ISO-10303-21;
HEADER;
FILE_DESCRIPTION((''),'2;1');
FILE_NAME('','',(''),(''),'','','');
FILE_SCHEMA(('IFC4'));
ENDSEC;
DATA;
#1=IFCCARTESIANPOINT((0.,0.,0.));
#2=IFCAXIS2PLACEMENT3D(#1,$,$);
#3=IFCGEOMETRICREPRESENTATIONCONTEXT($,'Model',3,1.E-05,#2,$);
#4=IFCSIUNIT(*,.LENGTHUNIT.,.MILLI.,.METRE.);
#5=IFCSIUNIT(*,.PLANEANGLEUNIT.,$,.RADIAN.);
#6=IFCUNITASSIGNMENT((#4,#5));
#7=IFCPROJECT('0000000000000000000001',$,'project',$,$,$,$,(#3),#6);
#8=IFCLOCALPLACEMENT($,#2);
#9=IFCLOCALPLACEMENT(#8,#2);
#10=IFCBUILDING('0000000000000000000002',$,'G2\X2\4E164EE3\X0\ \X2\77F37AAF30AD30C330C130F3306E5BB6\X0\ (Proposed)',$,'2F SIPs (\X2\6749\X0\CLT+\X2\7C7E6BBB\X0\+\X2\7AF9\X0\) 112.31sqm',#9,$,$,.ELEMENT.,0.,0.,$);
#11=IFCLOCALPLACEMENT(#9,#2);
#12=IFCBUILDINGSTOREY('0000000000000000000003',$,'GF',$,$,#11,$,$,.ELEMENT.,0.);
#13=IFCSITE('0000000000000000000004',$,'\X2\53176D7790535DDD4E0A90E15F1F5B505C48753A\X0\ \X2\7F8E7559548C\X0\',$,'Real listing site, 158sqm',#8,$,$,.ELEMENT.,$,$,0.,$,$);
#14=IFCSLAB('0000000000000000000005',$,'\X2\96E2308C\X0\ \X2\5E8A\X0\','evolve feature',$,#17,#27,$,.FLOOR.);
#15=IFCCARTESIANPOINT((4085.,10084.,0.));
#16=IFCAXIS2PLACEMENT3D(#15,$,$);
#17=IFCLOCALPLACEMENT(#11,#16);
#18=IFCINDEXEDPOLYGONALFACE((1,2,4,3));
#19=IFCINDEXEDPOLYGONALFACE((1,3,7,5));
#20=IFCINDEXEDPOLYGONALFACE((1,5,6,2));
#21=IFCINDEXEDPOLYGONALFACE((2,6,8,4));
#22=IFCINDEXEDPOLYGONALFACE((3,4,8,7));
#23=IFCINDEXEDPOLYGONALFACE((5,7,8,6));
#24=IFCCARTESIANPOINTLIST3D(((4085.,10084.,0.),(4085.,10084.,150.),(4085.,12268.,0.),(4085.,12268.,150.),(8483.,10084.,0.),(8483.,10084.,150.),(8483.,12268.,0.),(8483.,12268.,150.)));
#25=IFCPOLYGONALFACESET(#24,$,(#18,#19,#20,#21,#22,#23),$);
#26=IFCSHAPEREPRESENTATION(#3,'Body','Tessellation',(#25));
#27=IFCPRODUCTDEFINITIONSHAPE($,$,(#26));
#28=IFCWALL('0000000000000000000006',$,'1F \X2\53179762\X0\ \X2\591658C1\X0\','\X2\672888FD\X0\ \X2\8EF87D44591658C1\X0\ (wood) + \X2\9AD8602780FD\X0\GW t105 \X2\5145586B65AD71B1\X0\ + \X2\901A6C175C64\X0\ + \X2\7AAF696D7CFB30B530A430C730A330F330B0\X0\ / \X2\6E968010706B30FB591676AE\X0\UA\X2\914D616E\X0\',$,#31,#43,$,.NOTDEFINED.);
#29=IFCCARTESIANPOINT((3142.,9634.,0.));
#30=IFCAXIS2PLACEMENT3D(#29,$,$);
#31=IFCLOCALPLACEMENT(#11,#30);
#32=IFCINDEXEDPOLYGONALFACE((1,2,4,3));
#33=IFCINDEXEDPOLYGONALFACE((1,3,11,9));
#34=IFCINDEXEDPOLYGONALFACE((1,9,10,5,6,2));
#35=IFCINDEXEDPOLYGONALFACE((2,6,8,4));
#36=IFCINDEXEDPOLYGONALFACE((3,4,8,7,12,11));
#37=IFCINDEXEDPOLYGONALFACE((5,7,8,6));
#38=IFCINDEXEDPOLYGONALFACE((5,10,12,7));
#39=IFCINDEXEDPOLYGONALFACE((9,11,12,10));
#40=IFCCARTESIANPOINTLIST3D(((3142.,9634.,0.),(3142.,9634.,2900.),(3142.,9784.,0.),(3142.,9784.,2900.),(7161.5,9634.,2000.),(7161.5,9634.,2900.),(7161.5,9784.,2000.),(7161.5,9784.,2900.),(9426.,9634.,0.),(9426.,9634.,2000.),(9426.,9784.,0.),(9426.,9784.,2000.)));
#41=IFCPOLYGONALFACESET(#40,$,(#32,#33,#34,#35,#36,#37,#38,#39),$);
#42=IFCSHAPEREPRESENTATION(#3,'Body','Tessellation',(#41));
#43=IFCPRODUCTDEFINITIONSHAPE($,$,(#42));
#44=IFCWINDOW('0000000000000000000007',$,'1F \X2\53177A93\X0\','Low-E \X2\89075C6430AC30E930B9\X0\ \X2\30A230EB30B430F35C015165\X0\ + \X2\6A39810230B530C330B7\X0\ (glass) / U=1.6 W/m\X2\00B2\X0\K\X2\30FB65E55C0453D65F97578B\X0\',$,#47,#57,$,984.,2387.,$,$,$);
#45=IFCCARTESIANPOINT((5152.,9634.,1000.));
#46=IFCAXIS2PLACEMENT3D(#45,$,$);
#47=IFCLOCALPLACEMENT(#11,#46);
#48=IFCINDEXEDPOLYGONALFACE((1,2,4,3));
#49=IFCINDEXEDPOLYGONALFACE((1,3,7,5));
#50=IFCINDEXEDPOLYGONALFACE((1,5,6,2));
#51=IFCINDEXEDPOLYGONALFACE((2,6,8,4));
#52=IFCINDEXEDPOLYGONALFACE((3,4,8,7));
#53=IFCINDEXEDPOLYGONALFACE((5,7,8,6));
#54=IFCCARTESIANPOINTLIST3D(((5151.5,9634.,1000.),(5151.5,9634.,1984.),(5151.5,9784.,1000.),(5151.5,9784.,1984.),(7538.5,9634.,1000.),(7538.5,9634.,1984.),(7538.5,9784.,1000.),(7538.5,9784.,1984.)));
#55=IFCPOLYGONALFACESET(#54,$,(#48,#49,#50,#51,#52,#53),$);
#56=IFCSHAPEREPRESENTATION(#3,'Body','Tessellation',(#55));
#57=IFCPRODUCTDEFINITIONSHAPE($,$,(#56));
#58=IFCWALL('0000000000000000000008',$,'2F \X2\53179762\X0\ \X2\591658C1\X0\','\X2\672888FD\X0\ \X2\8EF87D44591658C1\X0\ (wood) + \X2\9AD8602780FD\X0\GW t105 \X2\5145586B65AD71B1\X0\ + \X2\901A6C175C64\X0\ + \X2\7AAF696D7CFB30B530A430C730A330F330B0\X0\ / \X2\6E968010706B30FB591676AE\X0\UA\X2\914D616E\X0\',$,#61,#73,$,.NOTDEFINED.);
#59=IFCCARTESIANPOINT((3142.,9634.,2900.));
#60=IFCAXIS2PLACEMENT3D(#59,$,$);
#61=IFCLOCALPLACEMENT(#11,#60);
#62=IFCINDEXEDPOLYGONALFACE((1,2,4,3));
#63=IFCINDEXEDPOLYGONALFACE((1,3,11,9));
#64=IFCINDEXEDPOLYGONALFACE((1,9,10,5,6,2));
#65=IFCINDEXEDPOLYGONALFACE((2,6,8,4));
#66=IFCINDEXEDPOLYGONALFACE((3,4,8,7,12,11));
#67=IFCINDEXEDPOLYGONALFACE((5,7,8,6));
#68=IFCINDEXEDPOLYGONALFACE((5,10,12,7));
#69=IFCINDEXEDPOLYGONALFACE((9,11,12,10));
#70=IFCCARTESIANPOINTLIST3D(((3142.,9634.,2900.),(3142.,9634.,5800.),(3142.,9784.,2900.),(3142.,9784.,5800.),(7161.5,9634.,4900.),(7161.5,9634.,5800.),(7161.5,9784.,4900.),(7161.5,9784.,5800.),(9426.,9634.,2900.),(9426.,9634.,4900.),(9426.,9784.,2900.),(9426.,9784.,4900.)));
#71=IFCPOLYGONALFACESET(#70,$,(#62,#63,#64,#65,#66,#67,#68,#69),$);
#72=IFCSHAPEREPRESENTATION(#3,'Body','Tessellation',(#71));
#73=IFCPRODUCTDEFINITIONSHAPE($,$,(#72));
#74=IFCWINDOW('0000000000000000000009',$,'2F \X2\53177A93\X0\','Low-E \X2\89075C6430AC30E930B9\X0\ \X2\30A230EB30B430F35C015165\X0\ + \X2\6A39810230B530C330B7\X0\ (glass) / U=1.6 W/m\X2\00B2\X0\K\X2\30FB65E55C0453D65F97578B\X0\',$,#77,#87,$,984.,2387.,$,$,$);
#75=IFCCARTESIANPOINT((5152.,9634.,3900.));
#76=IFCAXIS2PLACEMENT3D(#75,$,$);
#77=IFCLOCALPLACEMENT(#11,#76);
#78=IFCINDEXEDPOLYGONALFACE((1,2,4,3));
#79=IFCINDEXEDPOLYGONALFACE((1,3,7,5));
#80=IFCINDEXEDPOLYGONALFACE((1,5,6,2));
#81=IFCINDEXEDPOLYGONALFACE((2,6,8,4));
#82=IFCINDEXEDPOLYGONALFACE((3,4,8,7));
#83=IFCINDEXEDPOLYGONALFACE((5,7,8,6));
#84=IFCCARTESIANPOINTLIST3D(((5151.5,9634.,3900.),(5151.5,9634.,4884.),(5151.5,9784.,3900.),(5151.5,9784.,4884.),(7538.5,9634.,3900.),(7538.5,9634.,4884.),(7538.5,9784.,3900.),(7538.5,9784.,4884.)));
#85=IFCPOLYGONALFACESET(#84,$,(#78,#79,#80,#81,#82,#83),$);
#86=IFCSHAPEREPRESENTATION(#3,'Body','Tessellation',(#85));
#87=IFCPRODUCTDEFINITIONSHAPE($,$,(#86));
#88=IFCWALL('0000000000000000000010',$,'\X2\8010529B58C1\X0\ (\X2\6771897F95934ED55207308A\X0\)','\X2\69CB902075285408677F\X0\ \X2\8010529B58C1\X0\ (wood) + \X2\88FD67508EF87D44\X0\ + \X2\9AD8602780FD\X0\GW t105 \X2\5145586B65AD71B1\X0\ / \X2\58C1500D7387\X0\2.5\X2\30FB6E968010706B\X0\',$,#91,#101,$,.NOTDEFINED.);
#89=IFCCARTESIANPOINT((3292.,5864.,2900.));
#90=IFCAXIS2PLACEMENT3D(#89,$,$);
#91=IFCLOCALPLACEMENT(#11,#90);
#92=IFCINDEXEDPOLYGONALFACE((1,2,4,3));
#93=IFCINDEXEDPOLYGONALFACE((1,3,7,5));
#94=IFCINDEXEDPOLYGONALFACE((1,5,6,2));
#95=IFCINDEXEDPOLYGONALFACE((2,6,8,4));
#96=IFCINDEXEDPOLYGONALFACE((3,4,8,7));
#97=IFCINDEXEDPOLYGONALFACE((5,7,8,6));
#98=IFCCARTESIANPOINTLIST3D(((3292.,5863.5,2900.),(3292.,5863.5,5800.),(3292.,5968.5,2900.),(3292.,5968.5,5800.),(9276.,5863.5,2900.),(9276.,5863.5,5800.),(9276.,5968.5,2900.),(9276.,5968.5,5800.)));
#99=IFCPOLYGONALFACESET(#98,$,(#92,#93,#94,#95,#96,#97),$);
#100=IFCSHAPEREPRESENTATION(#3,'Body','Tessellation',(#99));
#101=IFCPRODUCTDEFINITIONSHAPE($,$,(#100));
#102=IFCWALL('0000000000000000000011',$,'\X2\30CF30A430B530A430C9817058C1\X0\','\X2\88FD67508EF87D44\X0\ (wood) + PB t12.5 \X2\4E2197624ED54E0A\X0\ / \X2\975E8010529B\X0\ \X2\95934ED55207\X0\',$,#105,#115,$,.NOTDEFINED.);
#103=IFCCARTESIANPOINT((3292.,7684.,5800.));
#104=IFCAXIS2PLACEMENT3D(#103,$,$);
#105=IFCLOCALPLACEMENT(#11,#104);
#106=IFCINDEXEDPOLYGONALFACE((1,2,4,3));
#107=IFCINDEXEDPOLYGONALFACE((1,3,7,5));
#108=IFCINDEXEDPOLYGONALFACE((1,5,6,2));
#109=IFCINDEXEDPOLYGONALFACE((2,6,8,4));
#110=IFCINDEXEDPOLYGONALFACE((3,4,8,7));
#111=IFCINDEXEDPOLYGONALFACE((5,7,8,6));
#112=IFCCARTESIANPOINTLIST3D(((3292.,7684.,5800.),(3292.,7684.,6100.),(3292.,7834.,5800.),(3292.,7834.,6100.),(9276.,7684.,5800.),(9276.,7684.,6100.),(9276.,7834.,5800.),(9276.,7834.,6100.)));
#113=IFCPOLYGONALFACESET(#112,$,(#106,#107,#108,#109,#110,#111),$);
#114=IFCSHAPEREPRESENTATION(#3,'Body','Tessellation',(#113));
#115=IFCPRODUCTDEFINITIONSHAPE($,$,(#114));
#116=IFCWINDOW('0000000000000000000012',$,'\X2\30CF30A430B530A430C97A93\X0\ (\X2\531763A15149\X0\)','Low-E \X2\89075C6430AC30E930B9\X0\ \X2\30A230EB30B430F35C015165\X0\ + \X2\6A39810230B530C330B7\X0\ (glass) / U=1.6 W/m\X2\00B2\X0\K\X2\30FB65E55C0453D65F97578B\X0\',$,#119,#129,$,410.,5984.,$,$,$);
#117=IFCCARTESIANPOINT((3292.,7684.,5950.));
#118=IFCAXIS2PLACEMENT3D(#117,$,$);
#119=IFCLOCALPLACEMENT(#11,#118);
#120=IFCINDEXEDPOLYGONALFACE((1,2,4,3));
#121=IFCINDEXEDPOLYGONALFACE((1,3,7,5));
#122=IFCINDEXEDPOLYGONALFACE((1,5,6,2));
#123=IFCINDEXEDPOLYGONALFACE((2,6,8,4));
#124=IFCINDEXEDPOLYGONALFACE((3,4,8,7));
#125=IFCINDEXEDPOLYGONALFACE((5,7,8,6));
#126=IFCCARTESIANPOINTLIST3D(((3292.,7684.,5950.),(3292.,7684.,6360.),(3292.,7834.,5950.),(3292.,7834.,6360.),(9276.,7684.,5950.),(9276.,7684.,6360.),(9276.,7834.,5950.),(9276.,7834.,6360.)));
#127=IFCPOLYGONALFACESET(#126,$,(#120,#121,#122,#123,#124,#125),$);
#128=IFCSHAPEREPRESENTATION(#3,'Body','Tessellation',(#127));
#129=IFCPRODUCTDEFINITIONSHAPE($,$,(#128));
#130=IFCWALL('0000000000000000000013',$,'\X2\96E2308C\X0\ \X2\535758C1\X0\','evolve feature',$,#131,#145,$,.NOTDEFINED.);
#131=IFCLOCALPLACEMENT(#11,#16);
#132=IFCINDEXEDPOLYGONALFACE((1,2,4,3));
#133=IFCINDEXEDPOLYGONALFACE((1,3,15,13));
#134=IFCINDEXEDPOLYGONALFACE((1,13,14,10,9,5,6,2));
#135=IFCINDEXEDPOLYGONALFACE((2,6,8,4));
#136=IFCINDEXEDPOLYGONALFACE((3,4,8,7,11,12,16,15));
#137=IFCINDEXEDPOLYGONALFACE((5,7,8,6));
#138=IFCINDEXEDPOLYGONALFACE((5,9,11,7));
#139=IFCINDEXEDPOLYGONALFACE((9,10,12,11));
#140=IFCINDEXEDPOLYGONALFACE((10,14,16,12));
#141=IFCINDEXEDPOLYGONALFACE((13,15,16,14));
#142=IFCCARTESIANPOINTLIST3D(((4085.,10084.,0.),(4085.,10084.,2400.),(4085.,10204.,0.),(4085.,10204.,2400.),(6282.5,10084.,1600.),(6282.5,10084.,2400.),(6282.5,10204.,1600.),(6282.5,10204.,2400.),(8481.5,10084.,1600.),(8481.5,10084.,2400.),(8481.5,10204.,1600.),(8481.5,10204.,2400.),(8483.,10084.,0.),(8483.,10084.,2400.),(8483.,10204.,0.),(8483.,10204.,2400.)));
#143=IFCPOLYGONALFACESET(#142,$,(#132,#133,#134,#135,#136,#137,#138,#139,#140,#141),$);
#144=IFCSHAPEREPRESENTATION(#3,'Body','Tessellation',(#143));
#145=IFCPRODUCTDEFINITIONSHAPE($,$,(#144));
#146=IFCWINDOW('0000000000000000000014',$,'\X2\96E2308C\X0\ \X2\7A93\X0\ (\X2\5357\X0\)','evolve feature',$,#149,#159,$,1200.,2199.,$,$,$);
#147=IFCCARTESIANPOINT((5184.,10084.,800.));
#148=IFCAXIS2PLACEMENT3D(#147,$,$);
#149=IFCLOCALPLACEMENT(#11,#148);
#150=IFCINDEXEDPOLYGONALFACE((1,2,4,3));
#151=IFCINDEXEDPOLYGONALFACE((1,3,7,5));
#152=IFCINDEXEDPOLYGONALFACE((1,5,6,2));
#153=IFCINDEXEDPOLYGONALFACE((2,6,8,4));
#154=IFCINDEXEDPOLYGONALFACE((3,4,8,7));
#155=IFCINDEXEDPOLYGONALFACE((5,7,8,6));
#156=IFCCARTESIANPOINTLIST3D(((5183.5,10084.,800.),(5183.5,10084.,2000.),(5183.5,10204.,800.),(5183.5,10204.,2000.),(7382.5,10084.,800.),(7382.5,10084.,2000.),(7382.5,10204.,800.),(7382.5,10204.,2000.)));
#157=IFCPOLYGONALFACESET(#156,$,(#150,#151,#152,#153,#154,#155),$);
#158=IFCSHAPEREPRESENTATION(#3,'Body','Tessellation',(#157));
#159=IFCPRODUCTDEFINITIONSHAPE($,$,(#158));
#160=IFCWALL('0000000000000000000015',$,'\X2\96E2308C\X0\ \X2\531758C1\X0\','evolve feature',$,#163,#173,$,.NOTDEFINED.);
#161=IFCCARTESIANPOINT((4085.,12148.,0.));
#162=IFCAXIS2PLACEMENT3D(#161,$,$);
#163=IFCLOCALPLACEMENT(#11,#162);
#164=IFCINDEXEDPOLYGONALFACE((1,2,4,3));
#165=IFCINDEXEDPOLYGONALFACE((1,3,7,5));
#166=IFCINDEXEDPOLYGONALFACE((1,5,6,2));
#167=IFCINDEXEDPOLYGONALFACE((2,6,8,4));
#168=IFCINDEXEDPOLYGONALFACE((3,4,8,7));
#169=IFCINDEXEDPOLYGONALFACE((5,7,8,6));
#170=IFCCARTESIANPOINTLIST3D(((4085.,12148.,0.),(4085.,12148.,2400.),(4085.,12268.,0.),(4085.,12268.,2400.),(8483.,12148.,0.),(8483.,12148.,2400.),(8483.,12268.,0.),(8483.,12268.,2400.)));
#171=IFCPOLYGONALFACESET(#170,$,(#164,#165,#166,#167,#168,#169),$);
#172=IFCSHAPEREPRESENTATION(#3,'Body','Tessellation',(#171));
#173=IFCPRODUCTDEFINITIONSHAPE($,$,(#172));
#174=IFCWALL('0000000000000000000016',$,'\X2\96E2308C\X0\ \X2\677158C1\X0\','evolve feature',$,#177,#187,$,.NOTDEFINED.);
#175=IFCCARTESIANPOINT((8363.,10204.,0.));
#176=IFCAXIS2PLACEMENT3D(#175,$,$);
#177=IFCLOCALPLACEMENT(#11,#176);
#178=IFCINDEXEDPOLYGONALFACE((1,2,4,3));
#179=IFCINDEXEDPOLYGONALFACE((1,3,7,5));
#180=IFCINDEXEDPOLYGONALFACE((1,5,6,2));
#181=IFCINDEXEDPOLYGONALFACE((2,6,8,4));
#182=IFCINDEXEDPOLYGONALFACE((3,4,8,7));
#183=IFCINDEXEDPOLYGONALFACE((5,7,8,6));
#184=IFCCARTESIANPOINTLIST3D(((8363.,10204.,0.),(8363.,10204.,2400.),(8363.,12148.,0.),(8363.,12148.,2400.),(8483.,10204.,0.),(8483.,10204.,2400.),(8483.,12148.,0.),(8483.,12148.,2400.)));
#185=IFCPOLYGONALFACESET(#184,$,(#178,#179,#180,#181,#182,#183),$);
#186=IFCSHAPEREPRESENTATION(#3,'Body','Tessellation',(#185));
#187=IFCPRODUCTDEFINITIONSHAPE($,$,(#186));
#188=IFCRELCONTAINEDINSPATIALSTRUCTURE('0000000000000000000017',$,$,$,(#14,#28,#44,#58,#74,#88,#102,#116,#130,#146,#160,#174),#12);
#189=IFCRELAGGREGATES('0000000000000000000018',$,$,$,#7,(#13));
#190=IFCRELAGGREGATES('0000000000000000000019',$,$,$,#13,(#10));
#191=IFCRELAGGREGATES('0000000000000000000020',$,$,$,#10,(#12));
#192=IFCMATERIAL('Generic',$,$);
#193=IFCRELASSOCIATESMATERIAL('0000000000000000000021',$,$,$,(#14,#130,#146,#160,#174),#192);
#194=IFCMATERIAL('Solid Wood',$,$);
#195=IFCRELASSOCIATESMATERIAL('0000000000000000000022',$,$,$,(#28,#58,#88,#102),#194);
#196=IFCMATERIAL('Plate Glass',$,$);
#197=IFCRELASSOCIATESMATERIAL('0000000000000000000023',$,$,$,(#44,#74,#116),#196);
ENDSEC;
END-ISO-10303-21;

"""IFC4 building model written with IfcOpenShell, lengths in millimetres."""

from ifc_helpers import new_model, si_unit, frame, frame_2d, origin, place, context, project, spatial, rectangle, extrude, material, element, fill, save


model = new_model("IFC4")

# Units and contexts
model_context = context("Model", 3, precision=1e-05, world=origin())
ifc_project = project(units=[si_unit("LENGTHUNIT", "METRE", prefix="MILLI"), si_unit("PLANEANGLEUNIT", "RADIAN")], contexts=[model_context])

# Site, building, storey
site_placement = place(None, origin())
site = spatial("IfcSite", under=ifc_project, at=site_placement, Name="北海道川上郡弟子屈町 美留和", ObjectType="Real listing site, 158sqm", CompositionType="ELEMENT", RefElevation=0.0)
building_placement = place(site_placement, origin())
building = spatial("IfcBuilding", under=site, at=building_placement, Name="G2世代 石窯キッチンの家 (Proposed)", ObjectType="2F SIPs (杉CLT+籾殻+竹) 112.31sqm", CompositionType="ELEMENT", ElevationOfRefHeight=0.0, ElevationOfTerrain=0.0)
storey_placement = place(building_placement, origin())
storey = spatial("IfcBuildingStorey", under=building, at=storey_placement, Name="GF", CompositionType="ELEMENT", Elevation=0.0)

# Slab
ifc_material_1 = material(Name="Generic")
slab_placement = place(storey_placement, frame((4085.0, 10084.0, 0.0)))
element("IfcSlab", 1, at=slab_placement, inside=storey, material=ifc_material_1, Name="離れ 床", Description="evolve feature", PredefinedType="FLOOR", context=model_context, shape_type="SweptSolid", body=[
    extrude(rectangle(XDim=4398.0, YDim=2184.0, at=frame_2d((2199.0, 1092.0))), frame((4085.0, 10084.0, 0.0)), (0.0, 0.0, 1.0), 150.0),
])

# Wall, opening, window
ifc_material_2 = material(Name="Solid Wood")
wall_1_placement = place(storey_placement, frame((3142.0, 9634.0, 0.0)))
wall_1 = element("IfcWall", 2, at=wall_1_placement, inside=storey, material=ifc_material_2, Name="1F 北面 外壁", Description="木製 軸組外壁 (wood) + 高性能GW t105 充填断熱 + 通気層 + 窯業系サイディング / 準耐火・外皮UA配慮", PredefinedType="NOTDEFINED", context=model_context, shape_type="SweptSolid", body=[
    extrude(rectangle(XDim=6284.0, YDim=150.0, at=frame_2d((3142.0, 75.0))), frame((3142.0, 9634.0, 0.0)), (0.0, 0.0, 1.0), 2900.0),
])
opening_1_placement = place(storey_placement, frame((5152.0, 9634.0, 1000.0)))
opening_1 = element("IfcOpeningElement", 3, at=opening_1_placement, cuts=wall_1, PredefinedType="NOTDEFINED", context=model_context, shape_type="SweptSolid", body=[
    extrude(rectangle(XDim=2387.0, YDim=150.0, at=frame_2d((1193.0, 75.0))), frame((5152.0, 9634.0, 1000.0)), (0.0, 0.0, 1.0), 984.0),
])
ifc_material_3 = material(Name="Plate Glass")
window_1_placement = place(storey_placement, frame((5152.0, 9634.0, 1000.0)))
window_1 = element("IfcWindow", 4, at=window_1_placement, inside=storey, material=ifc_material_3, Name="1F 北窓", Description="Low-E 複層ガラス アルゴン封入 + 樹脂サッシ (glass) / U=1.6 W/m²K・日射取得型", OverallHeight=984.0, OverallWidth=2387.0, context=model_context, shape_type="SweptSolid", body=[
    extrude(rectangle(XDim=2387.0, YDim=150.0, at=frame_2d((1193.0, 75.0))), frame((5152.0, 9634.0, 1000.0)), (0.0, 0.0, 1.0), 984.0),
])
fill(opening_1, window_1)

# Wall, opening, window
wall_2_placement = place(storey_placement, frame((3142.0, 9634.0, 2900.0)))
wall_2 = element("IfcWall", 5, at=wall_2_placement, inside=storey, material=ifc_material_2, Name="2F 北面 外壁", Description="木製 軸組外壁 (wood) + 高性能GW t105 充填断熱 + 通気層 + 窯業系サイディング / 準耐火・外皮UA配慮", PredefinedType="NOTDEFINED", context=model_context, shape_type="SweptSolid", body=[
    extrude(rectangle(XDim=6284.0, YDim=150.0, at=frame_2d((3142.0, 75.0))), frame((3142.0, 9634.0, 2900.0)), (0.0, 0.0, 1.0), 2900.0),
])
opening_2_placement = place(storey_placement, frame((5152.0, 9634.0, 3900.0)))
opening_2 = element("IfcOpeningElement", 6, at=opening_2_placement, cuts=wall_2, PredefinedType="NOTDEFINED", context=model_context, shape_type="SweptSolid", body=[
    extrude(rectangle(XDim=2387.0, YDim=150.0, at=frame_2d((1193.0, 75.0))), frame((5152.0, 9634.0, 3900.0)), (0.0, 0.0, 1.0), 984.0),
])
window_2_placement = place(storey_placement, frame((5152.0, 9634.0, 3900.0)))
window_2 = element("IfcWindow", 7, at=window_2_placement, inside=storey, material=ifc_material_3, Name="2F 北窓", Description="Low-E 複層ガラス アルゴン封入 + 樹脂サッシ (glass) / U=1.6 W/m²K・日射取得型", OverallHeight=984.0, OverallWidth=2387.0, context=model_context, shape_type="SweptSolid", body=[
    extrude(rectangle(XDim=2387.0, YDim=150.0, at=frame_2d((1193.0, 75.0))), frame((5152.0, 9634.0, 3900.0)), (0.0, 0.0, 1.0), 984.0),
])
fill(opening_2, window_2)

# Wall
wall_3_placement = place(storey_placement, frame((3292.0, 5864.0, 2900.0)))
element("IfcWall", 8, at=wall_3_placement, inside=storey, material=ifc_material_2, Name="耐力壁 (東西間仕切り)", Description="構造用合板 耐力壁 (wood) + 製材軸組 + 高性能GW t105 充填断熱 / 壁倍率2.5・準耐火", PredefinedType="NOTDEFINED", context=model_context, shape_type="SweptSolid", body=[
    extrude(rectangle(XDim=5984.0, YDim=105.0, at=frame_2d((2992.0, 52.0))), frame((3292.0, 5864.0, 2900.0)), (0.0, 0.0, 1.0), 2900.0),
])

# Walls, openings, windows
wall_4_placement = place(storey_placement, frame((3292.0, 7684.0, 5800.0)))
wall_4 = element("IfcWall", 9, at=wall_4_placement, inside=storey, material=ifc_material_2, Name="ハイサイド腰壁", Description="製材軸組 (wood) + PB t12.5 両面仕上 / 非耐力 間仕切", PredefinedType="NOTDEFINED", context=model_context, shape_type="SweptSolid", body=[
    extrude(rectangle(XDim=5984.0, YDim=150.0, at=frame_2d((2992.0, 75.0))), frame((3292.0, 7684.0, 5800.0)), (0.0, 0.0, 1.0), 700.0),
])
opening_3_placement = place(storey_placement, frame((3292.0, 7684.0, 5950.0)))
opening_3 = element("IfcOpeningElement", 10, at=opening_3_placement, cuts=wall_4, PredefinedType="NOTDEFINED", context=model_context, shape_type="SweptSolid", body=[
    extrude(rectangle(XDim=5984.0, YDim=150.0, at=frame_2d((2992.0, 75.0))), frame((3292.0, 7684.0, 5950.0)), (0.0, 0.0, 1.0), 410.0),
])
window_3_placement = place(storey_placement, frame((3292.0, 7684.0, 5950.0)))
window_3 = element("IfcWindow", 11, at=window_3_placement, inside=storey, material=ifc_material_3, Name="ハイサイド窓 (北採光)", Description="Low-E 複層ガラス アルゴン封入 + 樹脂サッシ (glass) / U=1.6 W/m²K・日射取得型", OverallHeight=410.0, OverallWidth=5984.0, context=model_context, shape_type="SweptSolid", body=[
    extrude(rectangle(XDim=5984.0, YDim=150.0, at=frame_2d((2992.0, 75.0))), frame((3292.0, 7684.0, 5950.0)), (0.0, 0.0, 1.0), 410.0),
])
fill(opening_3, window_3)
wall_5_placement = place(storey_placement, frame((4085.0, 10084.0, 0.0)))
wall_5 = element("IfcWall", 12, at=wall_5_placement, inside=storey, material=ifc_material_1, Name="離れ 南壁", Description="evolve feature", PredefinedType="NOTDEFINED", context=model_context, shape_type="SweptSolid", body=[
    extrude(rectangle(XDim=4398.0, YDim=120.0, at=frame_2d((2199.0, 60.0))), frame((4085.0, 10084.0, 0.0)), (0.0, 0.0, 1.0), 2400.0),
])
opening_4_placement = place(storey_placement, frame((5184.0, 10084.0, 800.0)))
opening_4 = element("IfcOpeningElement", 13, at=opening_4_placement, cuts=wall_5, PredefinedType="NOTDEFINED", context=model_context, shape_type="SweptSolid", body=[
    extrude(rectangle(XDim=2199.0, YDim=120.0, at=frame_2d((1099.0, 60.0))), frame((5184.0, 10084.0, 800.0)), (0.0, 0.0, 1.0), 1200.0),
])
window_4_placement = place(storey_placement, frame((5184.0, 10084.0, 800.0)))
window_4 = element("IfcWindow", 14, at=window_4_placement, inside=storey, material=ifc_material_1, Name="離れ 窓 (南)", Description="evolve feature", OverallHeight=1200.0, OverallWidth=2199.0, context=model_context, shape_type="SweptSolid", body=[
    extrude(rectangle(XDim=2199.0, YDim=120.0, at=frame_2d((1099.0, 60.0))), frame((5184.0, 10084.0, 800.0)), (0.0, 0.0, 1.0), 1200.0),
])
fill(opening_4, window_4)

# Walls
wall_6_placement = place(storey_placement, frame((4085.0, 12148.0, 0.0)))
element("IfcWall", 15, at=wall_6_placement, inside=storey, material=ifc_material_1, Name="離れ 北壁", Description="evolve feature", PredefinedType="NOTDEFINED", context=model_context, shape_type="SweptSolid", body=[
    extrude(rectangle(XDim=4398.0, YDim=120.0, at=frame_2d((2199.0, 60.0))), frame((4085.0, 12148.0, 0.0)), (0.0, 0.0, 1.0), 2400.0),
])
wall_7_placement = place(storey_placement, frame((8363.0, 10204.0, 0.0)))
element("IfcWall", 16, at=wall_7_placement, inside=storey, material=ifc_material_1, Name="離れ 東壁", Description="evolve feature", PredefinedType="NOTDEFINED", context=model_context, shape_type="SweptSolid", body=[
    extrude(rectangle(XDim=120.0, YDim=1944.0, at=frame_2d((60.0, 972.0))), frame((8363.0, 10204.0, 0.0)), (0.0, 0.0, 1.0), 2400.0),
])

save(model, "model.ifc")
